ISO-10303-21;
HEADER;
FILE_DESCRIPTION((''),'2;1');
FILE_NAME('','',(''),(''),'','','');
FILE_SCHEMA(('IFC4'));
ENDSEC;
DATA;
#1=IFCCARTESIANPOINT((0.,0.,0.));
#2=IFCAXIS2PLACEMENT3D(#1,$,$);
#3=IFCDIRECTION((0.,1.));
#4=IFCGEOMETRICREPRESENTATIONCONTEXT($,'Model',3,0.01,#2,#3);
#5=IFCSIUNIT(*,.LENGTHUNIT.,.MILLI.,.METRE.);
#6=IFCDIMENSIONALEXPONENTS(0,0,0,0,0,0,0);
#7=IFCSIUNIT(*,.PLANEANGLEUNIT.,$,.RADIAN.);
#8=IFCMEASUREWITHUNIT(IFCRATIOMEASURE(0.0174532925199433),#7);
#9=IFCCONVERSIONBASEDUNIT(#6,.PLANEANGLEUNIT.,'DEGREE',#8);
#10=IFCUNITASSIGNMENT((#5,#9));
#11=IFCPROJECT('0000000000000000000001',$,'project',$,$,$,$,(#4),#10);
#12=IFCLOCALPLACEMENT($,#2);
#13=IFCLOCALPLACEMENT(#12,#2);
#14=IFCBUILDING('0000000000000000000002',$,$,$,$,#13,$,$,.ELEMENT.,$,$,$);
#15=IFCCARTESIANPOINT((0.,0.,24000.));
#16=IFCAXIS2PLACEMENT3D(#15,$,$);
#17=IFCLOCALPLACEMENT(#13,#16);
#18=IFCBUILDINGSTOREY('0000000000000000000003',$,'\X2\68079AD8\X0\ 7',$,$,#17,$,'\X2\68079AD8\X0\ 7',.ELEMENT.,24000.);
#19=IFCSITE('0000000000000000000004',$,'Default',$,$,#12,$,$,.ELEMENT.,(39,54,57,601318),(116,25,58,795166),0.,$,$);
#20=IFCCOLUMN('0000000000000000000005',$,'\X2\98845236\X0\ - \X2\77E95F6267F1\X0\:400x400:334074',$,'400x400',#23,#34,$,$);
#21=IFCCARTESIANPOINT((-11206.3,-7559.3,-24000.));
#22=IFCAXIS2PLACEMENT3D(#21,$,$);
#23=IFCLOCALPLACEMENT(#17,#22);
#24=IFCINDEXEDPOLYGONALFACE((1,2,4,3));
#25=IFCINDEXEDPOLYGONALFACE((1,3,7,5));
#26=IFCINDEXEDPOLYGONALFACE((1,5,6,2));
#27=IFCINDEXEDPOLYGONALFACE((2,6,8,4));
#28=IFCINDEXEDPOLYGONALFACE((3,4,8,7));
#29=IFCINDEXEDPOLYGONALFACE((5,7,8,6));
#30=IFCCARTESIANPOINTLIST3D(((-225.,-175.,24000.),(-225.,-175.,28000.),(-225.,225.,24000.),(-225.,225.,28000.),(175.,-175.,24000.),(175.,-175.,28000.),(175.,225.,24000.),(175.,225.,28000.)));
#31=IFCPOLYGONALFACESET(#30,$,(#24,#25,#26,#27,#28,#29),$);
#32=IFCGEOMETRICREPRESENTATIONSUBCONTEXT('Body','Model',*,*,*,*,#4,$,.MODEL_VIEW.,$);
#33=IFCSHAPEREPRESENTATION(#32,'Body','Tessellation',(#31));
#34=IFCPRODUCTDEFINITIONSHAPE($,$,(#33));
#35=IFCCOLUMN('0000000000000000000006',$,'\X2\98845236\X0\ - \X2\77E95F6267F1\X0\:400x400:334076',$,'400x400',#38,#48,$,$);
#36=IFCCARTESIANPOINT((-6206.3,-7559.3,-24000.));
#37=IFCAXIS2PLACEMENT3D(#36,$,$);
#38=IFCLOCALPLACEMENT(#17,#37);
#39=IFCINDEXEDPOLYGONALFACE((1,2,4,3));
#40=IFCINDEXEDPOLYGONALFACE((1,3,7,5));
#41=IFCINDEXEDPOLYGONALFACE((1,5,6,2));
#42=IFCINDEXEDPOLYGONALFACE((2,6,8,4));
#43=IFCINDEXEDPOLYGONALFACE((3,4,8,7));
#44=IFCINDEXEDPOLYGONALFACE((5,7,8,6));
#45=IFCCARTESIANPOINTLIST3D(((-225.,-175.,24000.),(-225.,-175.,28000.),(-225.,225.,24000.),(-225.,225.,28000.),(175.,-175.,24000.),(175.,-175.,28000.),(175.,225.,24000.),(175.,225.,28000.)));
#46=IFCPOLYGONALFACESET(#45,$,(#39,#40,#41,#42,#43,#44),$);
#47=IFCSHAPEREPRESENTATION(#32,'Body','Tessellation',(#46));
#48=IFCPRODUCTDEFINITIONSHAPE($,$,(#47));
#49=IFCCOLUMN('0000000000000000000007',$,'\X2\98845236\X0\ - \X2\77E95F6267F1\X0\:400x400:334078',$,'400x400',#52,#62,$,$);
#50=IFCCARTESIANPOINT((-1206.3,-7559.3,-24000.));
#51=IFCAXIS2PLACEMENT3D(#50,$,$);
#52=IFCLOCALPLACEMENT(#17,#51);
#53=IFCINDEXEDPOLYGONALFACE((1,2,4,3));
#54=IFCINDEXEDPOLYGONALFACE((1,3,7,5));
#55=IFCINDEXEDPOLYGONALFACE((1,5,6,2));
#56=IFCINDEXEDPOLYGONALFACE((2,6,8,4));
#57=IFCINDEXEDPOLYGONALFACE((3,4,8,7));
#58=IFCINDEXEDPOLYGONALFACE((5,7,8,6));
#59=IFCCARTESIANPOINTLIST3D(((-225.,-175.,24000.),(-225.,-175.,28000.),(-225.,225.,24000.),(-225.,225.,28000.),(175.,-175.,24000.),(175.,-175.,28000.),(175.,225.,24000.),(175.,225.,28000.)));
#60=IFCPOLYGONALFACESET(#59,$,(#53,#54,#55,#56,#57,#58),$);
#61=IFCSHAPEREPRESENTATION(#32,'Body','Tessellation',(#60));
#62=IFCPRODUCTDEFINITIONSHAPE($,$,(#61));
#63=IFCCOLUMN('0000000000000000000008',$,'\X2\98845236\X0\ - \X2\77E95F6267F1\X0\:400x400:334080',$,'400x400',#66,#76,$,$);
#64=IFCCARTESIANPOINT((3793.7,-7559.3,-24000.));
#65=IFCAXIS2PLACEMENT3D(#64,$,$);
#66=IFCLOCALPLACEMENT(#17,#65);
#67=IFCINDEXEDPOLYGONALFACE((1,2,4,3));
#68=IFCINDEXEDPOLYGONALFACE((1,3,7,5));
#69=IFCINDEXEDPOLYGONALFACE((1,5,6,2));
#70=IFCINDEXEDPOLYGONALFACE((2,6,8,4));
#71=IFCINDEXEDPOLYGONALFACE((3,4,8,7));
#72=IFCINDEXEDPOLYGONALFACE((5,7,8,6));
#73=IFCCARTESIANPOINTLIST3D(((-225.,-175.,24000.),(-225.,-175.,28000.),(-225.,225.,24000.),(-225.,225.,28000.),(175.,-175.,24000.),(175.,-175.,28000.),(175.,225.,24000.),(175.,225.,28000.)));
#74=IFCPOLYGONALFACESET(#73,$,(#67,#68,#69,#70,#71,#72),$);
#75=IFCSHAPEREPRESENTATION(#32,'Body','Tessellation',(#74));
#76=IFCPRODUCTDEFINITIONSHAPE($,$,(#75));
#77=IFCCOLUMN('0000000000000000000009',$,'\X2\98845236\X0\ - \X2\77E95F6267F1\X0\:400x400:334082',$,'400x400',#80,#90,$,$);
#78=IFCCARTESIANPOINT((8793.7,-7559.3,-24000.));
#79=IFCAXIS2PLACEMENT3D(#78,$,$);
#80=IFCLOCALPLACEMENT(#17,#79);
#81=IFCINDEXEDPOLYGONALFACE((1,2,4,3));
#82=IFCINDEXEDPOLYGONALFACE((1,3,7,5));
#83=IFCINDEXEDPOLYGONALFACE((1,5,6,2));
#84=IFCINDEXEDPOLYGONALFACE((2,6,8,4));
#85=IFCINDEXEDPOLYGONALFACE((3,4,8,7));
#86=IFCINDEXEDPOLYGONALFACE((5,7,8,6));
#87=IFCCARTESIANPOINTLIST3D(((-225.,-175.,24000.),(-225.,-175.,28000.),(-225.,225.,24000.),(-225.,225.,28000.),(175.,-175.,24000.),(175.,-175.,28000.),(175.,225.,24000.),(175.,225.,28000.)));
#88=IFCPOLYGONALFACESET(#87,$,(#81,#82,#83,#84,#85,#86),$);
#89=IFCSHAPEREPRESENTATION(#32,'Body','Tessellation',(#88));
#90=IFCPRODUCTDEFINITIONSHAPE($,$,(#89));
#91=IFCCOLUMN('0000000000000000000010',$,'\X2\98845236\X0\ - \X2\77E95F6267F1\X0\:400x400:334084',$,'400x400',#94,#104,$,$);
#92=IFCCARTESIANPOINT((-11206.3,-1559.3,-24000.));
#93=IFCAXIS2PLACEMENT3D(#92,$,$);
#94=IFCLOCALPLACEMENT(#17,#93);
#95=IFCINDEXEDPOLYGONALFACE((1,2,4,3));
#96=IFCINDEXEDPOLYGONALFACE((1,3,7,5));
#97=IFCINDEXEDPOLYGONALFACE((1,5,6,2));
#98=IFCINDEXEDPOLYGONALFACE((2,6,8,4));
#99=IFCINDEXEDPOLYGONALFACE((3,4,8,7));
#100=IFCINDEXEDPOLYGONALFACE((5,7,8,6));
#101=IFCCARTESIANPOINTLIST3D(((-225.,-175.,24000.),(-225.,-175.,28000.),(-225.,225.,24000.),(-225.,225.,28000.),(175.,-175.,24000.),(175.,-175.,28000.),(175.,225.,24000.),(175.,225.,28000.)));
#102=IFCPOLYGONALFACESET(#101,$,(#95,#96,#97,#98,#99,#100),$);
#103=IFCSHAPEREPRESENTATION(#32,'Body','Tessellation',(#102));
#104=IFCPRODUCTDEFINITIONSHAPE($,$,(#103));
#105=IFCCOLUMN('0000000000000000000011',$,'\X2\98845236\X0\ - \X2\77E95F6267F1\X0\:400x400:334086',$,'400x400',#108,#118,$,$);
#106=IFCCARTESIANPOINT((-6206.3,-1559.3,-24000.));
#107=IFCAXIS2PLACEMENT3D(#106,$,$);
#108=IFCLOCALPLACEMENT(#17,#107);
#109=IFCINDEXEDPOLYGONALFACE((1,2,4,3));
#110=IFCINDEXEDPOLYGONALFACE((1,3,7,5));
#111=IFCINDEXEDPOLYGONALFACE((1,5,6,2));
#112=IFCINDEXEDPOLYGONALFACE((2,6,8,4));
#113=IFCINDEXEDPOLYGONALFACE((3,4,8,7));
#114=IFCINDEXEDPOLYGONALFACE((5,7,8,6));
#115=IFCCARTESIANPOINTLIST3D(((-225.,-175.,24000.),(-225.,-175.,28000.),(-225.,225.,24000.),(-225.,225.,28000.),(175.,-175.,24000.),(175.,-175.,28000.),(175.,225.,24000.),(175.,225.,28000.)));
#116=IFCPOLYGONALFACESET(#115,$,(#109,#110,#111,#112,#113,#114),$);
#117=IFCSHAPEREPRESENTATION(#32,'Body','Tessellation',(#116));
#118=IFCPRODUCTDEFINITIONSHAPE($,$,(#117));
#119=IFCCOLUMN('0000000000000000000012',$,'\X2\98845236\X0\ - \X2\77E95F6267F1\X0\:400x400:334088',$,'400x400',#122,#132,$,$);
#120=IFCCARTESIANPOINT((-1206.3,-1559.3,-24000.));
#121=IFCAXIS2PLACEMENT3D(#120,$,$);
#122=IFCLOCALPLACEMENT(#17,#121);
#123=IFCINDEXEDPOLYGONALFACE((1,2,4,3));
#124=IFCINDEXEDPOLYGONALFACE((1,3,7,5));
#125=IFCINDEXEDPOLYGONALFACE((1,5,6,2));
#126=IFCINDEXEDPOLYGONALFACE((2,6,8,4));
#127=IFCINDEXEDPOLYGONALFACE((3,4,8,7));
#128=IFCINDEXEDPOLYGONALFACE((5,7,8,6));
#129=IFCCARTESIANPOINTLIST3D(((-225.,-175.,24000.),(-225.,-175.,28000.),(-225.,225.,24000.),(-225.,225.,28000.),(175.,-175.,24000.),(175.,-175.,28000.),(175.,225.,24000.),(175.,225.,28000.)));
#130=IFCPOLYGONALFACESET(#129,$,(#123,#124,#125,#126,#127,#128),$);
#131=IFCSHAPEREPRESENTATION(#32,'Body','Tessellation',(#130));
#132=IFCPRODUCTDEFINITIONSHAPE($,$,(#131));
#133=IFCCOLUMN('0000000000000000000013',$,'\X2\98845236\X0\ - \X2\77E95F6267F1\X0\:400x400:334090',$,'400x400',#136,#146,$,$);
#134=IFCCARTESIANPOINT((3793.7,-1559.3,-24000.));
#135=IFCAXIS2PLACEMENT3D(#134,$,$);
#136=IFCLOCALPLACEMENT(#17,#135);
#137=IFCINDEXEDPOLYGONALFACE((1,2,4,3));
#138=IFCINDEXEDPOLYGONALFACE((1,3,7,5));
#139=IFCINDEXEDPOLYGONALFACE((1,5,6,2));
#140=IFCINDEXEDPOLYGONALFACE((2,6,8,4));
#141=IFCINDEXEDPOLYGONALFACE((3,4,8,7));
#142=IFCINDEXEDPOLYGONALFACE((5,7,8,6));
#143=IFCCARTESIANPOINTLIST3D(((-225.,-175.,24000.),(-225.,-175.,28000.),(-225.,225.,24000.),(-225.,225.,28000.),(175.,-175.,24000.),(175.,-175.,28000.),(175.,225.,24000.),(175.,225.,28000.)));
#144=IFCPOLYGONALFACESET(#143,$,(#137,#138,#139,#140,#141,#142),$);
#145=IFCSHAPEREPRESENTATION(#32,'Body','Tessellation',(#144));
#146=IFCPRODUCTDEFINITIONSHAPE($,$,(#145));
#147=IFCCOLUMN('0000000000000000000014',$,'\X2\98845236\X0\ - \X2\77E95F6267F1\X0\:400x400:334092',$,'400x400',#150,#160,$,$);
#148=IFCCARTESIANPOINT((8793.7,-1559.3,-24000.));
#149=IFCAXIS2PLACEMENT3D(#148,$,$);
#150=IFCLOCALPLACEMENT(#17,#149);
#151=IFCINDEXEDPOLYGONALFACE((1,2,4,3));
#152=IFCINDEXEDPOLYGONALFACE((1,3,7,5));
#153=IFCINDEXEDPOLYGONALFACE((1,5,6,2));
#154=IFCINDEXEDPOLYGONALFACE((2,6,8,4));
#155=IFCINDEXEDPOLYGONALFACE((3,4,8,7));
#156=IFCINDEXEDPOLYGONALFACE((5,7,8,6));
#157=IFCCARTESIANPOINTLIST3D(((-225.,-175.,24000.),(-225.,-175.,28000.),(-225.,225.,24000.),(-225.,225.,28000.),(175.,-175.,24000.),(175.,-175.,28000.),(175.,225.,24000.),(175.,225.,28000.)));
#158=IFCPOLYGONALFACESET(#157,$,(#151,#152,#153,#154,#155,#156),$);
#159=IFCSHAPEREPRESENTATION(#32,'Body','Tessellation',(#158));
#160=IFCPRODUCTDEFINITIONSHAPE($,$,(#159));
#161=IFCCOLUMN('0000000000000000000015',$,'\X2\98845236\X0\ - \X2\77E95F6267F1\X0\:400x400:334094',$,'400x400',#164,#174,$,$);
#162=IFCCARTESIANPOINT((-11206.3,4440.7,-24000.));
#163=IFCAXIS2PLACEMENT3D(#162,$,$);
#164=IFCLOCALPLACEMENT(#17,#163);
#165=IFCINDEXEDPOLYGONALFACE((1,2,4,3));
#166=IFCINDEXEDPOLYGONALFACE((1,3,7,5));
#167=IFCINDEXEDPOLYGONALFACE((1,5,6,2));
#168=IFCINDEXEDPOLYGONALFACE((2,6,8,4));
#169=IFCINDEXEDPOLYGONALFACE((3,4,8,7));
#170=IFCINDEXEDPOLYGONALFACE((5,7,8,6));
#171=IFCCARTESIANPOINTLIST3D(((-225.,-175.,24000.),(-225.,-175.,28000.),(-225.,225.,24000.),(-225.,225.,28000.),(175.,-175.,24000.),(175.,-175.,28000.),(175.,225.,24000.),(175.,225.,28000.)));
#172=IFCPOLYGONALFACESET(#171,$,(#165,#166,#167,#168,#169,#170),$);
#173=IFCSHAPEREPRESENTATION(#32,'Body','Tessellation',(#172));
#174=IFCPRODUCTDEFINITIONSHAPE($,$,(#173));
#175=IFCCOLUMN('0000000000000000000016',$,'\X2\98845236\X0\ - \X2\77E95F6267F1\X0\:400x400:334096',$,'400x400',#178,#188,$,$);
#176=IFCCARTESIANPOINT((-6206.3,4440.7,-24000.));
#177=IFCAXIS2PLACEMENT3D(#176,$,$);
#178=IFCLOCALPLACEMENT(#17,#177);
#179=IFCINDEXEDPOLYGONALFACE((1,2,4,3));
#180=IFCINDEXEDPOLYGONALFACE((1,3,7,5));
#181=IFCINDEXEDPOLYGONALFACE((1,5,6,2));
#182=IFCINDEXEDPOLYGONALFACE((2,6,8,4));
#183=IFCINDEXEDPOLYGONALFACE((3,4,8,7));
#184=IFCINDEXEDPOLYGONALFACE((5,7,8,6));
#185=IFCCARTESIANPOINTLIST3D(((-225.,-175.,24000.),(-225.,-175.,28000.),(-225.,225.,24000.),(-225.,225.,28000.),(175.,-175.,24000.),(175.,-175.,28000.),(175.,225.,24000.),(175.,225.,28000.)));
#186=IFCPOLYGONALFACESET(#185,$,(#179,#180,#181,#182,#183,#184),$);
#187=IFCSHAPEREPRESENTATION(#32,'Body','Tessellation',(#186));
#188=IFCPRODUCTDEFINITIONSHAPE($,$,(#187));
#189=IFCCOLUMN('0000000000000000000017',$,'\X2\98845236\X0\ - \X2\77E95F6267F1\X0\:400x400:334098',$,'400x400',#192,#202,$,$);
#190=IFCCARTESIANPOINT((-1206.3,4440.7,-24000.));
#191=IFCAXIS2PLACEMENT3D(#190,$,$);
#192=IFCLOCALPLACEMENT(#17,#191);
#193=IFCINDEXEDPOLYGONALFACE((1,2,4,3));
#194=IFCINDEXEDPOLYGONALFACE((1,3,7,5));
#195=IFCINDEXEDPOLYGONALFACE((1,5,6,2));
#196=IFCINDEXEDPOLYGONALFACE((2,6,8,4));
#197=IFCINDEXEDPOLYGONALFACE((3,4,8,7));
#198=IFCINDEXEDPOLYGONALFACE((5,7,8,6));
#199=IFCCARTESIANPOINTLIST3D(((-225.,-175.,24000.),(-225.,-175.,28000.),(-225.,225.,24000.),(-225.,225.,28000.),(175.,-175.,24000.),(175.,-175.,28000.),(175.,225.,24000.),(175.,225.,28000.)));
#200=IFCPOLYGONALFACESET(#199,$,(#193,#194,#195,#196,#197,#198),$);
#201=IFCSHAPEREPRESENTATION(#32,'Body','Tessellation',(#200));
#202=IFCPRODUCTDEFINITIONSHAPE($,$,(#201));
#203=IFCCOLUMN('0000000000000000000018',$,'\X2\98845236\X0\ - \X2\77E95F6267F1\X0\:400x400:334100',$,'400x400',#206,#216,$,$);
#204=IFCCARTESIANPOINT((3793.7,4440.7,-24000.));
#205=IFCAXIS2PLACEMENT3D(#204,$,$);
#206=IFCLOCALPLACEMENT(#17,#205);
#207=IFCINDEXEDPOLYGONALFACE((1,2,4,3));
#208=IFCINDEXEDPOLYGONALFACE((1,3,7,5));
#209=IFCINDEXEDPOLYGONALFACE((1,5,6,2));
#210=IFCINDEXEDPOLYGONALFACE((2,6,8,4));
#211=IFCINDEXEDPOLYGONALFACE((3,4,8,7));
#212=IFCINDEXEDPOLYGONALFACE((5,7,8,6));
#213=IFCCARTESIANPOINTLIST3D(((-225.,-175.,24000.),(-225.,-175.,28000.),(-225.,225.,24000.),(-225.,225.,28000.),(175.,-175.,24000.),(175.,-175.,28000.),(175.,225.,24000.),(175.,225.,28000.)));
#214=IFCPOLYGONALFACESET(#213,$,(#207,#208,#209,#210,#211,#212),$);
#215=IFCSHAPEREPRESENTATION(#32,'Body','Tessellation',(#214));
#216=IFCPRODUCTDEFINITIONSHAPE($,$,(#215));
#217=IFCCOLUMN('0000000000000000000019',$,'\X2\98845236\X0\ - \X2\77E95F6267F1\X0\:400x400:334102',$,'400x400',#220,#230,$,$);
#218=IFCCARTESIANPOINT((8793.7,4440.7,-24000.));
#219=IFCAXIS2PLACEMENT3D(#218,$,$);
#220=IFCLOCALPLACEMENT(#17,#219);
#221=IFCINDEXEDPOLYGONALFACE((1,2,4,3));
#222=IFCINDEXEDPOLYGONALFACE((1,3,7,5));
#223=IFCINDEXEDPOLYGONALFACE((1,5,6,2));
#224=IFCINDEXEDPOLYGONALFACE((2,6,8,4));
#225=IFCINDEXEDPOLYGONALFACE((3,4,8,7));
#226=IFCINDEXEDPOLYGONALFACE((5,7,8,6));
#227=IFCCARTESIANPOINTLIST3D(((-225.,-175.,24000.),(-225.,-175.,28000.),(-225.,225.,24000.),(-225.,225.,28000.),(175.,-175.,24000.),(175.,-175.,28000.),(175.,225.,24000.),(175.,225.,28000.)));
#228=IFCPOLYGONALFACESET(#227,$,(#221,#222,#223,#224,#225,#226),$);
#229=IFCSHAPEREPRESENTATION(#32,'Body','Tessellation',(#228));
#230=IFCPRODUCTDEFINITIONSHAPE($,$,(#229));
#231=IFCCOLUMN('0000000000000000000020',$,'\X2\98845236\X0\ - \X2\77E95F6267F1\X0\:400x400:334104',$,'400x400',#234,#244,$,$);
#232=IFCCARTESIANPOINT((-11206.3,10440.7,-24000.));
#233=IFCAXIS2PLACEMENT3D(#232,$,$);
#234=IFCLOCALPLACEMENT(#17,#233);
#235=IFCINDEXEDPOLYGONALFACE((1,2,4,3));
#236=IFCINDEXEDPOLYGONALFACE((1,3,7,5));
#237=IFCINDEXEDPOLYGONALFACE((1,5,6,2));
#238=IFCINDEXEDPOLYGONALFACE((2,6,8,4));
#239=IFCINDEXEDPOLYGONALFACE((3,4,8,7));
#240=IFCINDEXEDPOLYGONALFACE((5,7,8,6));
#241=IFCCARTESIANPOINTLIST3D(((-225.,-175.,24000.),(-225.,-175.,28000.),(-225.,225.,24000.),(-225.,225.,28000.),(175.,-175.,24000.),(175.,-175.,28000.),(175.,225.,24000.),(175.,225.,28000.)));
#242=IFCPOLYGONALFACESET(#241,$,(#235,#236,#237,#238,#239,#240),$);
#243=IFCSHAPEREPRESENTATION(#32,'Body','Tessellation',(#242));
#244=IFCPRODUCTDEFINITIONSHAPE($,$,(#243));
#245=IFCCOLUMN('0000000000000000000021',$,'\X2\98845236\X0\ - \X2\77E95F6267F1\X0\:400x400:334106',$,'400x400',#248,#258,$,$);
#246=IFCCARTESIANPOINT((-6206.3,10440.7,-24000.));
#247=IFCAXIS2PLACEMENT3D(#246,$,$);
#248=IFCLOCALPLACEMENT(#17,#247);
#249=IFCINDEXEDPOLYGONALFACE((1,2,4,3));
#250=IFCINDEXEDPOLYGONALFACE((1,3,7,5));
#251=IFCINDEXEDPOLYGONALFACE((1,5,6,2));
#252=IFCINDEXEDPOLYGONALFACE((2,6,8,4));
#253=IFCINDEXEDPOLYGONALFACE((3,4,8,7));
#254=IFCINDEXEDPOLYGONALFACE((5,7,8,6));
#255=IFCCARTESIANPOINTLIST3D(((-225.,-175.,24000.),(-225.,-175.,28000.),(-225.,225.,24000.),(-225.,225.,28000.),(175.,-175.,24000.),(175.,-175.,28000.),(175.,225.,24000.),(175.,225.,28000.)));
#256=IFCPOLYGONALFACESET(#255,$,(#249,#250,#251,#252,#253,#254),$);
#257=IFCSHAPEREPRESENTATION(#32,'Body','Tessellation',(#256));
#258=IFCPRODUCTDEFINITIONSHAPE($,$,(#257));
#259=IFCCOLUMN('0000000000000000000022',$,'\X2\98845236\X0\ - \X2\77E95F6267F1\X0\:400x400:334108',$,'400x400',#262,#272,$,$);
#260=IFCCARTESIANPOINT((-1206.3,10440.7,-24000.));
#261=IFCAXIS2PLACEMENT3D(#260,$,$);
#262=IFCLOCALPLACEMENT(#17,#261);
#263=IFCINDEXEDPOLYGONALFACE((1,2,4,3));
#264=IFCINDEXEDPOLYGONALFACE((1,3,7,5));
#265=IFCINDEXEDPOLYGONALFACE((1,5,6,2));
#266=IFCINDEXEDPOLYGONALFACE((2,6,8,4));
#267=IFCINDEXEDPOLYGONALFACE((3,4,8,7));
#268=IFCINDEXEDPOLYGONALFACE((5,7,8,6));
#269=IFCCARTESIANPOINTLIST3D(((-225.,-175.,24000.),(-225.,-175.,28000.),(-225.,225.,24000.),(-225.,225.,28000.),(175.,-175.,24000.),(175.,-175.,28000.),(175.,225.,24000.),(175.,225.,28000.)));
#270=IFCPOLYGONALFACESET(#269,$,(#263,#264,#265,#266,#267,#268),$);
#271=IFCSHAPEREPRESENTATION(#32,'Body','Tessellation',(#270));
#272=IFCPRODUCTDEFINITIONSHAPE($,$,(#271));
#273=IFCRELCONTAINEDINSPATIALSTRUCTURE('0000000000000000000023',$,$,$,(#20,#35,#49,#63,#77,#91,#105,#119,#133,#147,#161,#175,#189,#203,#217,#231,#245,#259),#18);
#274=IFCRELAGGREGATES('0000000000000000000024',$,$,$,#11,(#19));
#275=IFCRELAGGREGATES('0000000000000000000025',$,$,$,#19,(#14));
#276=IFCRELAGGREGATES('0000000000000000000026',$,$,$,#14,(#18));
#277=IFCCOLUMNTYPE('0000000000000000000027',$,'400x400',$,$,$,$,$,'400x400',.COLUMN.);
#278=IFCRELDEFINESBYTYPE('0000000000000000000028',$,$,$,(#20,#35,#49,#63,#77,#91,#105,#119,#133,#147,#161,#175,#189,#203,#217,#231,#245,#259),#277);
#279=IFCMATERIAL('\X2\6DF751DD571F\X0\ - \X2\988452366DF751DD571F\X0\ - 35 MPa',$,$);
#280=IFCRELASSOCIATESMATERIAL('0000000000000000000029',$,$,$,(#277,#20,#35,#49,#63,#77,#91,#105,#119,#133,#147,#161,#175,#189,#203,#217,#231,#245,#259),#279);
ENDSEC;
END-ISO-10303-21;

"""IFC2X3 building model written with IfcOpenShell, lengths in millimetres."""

from ifc_helpers import new_model, entity, si_unit, converted_unit, direction, frame, frame_2d, origin, place, context, subcontext, project, spatial, rectangle, extrude, source, transform, mapped, material, type_object, type_shapes, element, save


model = new_model("IFC2X3")

# Units and contexts
model_context = context("Model", 3, precision=0.01, world=origin(), true_north=direction((0.0, 1.0)))
body_context = subcontext(model_context, "Body", "Model", "MODEL_VIEW")
ifc_project = project(units=[si_unit("LENGTHUNIT", "METRE", prefix="MILLI"), converted_unit("PLANEANGLEUNIT", "DEGREE", entity("IfcRatioMeasure", 0.0174532925199433), si_unit("PLANEANGLEUNIT", "RADIAN"), dimensions=[0, 0, 0, 0, 0, 0, 0])], contexts=[model_context])

# Site, building, storey
site_placement = place(None, origin())
site = spatial("IfcSite", under=ifc_project, at=site_placement, Name="Default", CompositionType="ELEMENT", RefLatitude=(39, 54, 57, 601318), RefLongitude=(116, 25, 58, 795166), RefElevation=0.0)
building_placement = place(site_placement, origin())
building = spatial("IfcBuilding", under=site, at=building_placement, CompositionType="ELEMENT")
storey_placement = place(building_placement, frame((0.0, 0.0, 24000.0)))
storey = spatial("IfcBuildingStorey", under=building, at=storey_placement, Name="标高 7", LongName="标高 7", CompositionType="ELEMENT", Elevation=24000.0)

# Columns
ifc_material = material(Name="混凝土 - 预制混凝土 - 35 MPa")
column_type = type_object("IfcColumnType", Name="400x400", ElementType="400x400", PredefinedType="COLUMN", material=ifc_material)
shared_shape = source(origin(), body_context, "Body", "SweptSolid", [
    extrude(rectangle(XDim=400.0, YDim=400.0, at=frame_2d((0.0, 0.0), x_axis=(1.0, 0.0))), frame((-25.0, 25.0, 24000.0)), (0.0, 0.0, 1.0), 4000.0),
])
type_shapes(column_type, [shared_shape])
for number, where, name in (
    (1, (-11206.3, -7559.3, -24000.0), "预制 - 矩形柱:400x400:334074"),
    (2, (-6206.3, -7559.3, -24000.0), "预制 - 矩形柱:400x400:334076"),
    (3, (-1206.3, -7559.3, -24000.0), "预制 - 矩形柱:400x400:334078"),
    (4, (3793.7, -7559.3, -24000.0), "预制 - 矩形柱:400x400:334080"),
    (5, (8793.7, -7559.3, -24000.0), "预制 - 矩形柱:400x400:334082"),
    (6, (-11206.3, -1559.3, -24000.0), "预制 - 矩形柱:400x400:334084"),
    (7, (-6206.3, -1559.3, -24000.0), "预制 - 矩形柱:400x400:334086"),
    (8, (-1206.3, -1559.3, -24000.0), "预制 - 矩形柱:400x400:334088"),
    (9, (3793.7, -1559.3, -24000.0), "预制 - 矩形柱:400x400:334090"),
    (10, (8793.7, -1559.3, -24000.0), "预制 - 矩形柱:400x400:334092"),
    (11, (-11206.3, 4440.7, -24000.0), "预制 - 矩形柱:400x400:334094"),
    (12, (-6206.3, 4440.7, -24000.0), "预制 - 矩形柱:400x400:334096"),
    (13, (-1206.3, 4440.7, -24000.0), "预制 - 矩形柱:400x400:334098"),
    (14, (3793.7, 4440.7, -24000.0), "预制 - 矩形柱:400x400:334100"),
    (15, (8793.7, 4440.7, -24000.0), "预制 - 矩形柱:400x400:334102"),
    (16, (-11206.3, 10440.7, -24000.0), "预制 - 矩形柱:400x400:334104"),
    (17, (-6206.3, 10440.7, -24000.0), "预制 - 矩形柱:400x400:334106"),
    (18, (-1206.3, 10440.7, -24000.0), "预制 - 矩形柱:400x400:334108"),
):
    element("IfcColumn", number, at=place(storey_placement, frame(where)), inside=storey, type_object=column_type, material=ifc_material, Name=name, ObjectType="400x400", context=body_context, shape_type="MappedRepresentation", body=[
        mapped(shared_shape, transform((0.0, 0.0, 0.0), scale=1.0)),
    ])

save(model, "model.ifc")
